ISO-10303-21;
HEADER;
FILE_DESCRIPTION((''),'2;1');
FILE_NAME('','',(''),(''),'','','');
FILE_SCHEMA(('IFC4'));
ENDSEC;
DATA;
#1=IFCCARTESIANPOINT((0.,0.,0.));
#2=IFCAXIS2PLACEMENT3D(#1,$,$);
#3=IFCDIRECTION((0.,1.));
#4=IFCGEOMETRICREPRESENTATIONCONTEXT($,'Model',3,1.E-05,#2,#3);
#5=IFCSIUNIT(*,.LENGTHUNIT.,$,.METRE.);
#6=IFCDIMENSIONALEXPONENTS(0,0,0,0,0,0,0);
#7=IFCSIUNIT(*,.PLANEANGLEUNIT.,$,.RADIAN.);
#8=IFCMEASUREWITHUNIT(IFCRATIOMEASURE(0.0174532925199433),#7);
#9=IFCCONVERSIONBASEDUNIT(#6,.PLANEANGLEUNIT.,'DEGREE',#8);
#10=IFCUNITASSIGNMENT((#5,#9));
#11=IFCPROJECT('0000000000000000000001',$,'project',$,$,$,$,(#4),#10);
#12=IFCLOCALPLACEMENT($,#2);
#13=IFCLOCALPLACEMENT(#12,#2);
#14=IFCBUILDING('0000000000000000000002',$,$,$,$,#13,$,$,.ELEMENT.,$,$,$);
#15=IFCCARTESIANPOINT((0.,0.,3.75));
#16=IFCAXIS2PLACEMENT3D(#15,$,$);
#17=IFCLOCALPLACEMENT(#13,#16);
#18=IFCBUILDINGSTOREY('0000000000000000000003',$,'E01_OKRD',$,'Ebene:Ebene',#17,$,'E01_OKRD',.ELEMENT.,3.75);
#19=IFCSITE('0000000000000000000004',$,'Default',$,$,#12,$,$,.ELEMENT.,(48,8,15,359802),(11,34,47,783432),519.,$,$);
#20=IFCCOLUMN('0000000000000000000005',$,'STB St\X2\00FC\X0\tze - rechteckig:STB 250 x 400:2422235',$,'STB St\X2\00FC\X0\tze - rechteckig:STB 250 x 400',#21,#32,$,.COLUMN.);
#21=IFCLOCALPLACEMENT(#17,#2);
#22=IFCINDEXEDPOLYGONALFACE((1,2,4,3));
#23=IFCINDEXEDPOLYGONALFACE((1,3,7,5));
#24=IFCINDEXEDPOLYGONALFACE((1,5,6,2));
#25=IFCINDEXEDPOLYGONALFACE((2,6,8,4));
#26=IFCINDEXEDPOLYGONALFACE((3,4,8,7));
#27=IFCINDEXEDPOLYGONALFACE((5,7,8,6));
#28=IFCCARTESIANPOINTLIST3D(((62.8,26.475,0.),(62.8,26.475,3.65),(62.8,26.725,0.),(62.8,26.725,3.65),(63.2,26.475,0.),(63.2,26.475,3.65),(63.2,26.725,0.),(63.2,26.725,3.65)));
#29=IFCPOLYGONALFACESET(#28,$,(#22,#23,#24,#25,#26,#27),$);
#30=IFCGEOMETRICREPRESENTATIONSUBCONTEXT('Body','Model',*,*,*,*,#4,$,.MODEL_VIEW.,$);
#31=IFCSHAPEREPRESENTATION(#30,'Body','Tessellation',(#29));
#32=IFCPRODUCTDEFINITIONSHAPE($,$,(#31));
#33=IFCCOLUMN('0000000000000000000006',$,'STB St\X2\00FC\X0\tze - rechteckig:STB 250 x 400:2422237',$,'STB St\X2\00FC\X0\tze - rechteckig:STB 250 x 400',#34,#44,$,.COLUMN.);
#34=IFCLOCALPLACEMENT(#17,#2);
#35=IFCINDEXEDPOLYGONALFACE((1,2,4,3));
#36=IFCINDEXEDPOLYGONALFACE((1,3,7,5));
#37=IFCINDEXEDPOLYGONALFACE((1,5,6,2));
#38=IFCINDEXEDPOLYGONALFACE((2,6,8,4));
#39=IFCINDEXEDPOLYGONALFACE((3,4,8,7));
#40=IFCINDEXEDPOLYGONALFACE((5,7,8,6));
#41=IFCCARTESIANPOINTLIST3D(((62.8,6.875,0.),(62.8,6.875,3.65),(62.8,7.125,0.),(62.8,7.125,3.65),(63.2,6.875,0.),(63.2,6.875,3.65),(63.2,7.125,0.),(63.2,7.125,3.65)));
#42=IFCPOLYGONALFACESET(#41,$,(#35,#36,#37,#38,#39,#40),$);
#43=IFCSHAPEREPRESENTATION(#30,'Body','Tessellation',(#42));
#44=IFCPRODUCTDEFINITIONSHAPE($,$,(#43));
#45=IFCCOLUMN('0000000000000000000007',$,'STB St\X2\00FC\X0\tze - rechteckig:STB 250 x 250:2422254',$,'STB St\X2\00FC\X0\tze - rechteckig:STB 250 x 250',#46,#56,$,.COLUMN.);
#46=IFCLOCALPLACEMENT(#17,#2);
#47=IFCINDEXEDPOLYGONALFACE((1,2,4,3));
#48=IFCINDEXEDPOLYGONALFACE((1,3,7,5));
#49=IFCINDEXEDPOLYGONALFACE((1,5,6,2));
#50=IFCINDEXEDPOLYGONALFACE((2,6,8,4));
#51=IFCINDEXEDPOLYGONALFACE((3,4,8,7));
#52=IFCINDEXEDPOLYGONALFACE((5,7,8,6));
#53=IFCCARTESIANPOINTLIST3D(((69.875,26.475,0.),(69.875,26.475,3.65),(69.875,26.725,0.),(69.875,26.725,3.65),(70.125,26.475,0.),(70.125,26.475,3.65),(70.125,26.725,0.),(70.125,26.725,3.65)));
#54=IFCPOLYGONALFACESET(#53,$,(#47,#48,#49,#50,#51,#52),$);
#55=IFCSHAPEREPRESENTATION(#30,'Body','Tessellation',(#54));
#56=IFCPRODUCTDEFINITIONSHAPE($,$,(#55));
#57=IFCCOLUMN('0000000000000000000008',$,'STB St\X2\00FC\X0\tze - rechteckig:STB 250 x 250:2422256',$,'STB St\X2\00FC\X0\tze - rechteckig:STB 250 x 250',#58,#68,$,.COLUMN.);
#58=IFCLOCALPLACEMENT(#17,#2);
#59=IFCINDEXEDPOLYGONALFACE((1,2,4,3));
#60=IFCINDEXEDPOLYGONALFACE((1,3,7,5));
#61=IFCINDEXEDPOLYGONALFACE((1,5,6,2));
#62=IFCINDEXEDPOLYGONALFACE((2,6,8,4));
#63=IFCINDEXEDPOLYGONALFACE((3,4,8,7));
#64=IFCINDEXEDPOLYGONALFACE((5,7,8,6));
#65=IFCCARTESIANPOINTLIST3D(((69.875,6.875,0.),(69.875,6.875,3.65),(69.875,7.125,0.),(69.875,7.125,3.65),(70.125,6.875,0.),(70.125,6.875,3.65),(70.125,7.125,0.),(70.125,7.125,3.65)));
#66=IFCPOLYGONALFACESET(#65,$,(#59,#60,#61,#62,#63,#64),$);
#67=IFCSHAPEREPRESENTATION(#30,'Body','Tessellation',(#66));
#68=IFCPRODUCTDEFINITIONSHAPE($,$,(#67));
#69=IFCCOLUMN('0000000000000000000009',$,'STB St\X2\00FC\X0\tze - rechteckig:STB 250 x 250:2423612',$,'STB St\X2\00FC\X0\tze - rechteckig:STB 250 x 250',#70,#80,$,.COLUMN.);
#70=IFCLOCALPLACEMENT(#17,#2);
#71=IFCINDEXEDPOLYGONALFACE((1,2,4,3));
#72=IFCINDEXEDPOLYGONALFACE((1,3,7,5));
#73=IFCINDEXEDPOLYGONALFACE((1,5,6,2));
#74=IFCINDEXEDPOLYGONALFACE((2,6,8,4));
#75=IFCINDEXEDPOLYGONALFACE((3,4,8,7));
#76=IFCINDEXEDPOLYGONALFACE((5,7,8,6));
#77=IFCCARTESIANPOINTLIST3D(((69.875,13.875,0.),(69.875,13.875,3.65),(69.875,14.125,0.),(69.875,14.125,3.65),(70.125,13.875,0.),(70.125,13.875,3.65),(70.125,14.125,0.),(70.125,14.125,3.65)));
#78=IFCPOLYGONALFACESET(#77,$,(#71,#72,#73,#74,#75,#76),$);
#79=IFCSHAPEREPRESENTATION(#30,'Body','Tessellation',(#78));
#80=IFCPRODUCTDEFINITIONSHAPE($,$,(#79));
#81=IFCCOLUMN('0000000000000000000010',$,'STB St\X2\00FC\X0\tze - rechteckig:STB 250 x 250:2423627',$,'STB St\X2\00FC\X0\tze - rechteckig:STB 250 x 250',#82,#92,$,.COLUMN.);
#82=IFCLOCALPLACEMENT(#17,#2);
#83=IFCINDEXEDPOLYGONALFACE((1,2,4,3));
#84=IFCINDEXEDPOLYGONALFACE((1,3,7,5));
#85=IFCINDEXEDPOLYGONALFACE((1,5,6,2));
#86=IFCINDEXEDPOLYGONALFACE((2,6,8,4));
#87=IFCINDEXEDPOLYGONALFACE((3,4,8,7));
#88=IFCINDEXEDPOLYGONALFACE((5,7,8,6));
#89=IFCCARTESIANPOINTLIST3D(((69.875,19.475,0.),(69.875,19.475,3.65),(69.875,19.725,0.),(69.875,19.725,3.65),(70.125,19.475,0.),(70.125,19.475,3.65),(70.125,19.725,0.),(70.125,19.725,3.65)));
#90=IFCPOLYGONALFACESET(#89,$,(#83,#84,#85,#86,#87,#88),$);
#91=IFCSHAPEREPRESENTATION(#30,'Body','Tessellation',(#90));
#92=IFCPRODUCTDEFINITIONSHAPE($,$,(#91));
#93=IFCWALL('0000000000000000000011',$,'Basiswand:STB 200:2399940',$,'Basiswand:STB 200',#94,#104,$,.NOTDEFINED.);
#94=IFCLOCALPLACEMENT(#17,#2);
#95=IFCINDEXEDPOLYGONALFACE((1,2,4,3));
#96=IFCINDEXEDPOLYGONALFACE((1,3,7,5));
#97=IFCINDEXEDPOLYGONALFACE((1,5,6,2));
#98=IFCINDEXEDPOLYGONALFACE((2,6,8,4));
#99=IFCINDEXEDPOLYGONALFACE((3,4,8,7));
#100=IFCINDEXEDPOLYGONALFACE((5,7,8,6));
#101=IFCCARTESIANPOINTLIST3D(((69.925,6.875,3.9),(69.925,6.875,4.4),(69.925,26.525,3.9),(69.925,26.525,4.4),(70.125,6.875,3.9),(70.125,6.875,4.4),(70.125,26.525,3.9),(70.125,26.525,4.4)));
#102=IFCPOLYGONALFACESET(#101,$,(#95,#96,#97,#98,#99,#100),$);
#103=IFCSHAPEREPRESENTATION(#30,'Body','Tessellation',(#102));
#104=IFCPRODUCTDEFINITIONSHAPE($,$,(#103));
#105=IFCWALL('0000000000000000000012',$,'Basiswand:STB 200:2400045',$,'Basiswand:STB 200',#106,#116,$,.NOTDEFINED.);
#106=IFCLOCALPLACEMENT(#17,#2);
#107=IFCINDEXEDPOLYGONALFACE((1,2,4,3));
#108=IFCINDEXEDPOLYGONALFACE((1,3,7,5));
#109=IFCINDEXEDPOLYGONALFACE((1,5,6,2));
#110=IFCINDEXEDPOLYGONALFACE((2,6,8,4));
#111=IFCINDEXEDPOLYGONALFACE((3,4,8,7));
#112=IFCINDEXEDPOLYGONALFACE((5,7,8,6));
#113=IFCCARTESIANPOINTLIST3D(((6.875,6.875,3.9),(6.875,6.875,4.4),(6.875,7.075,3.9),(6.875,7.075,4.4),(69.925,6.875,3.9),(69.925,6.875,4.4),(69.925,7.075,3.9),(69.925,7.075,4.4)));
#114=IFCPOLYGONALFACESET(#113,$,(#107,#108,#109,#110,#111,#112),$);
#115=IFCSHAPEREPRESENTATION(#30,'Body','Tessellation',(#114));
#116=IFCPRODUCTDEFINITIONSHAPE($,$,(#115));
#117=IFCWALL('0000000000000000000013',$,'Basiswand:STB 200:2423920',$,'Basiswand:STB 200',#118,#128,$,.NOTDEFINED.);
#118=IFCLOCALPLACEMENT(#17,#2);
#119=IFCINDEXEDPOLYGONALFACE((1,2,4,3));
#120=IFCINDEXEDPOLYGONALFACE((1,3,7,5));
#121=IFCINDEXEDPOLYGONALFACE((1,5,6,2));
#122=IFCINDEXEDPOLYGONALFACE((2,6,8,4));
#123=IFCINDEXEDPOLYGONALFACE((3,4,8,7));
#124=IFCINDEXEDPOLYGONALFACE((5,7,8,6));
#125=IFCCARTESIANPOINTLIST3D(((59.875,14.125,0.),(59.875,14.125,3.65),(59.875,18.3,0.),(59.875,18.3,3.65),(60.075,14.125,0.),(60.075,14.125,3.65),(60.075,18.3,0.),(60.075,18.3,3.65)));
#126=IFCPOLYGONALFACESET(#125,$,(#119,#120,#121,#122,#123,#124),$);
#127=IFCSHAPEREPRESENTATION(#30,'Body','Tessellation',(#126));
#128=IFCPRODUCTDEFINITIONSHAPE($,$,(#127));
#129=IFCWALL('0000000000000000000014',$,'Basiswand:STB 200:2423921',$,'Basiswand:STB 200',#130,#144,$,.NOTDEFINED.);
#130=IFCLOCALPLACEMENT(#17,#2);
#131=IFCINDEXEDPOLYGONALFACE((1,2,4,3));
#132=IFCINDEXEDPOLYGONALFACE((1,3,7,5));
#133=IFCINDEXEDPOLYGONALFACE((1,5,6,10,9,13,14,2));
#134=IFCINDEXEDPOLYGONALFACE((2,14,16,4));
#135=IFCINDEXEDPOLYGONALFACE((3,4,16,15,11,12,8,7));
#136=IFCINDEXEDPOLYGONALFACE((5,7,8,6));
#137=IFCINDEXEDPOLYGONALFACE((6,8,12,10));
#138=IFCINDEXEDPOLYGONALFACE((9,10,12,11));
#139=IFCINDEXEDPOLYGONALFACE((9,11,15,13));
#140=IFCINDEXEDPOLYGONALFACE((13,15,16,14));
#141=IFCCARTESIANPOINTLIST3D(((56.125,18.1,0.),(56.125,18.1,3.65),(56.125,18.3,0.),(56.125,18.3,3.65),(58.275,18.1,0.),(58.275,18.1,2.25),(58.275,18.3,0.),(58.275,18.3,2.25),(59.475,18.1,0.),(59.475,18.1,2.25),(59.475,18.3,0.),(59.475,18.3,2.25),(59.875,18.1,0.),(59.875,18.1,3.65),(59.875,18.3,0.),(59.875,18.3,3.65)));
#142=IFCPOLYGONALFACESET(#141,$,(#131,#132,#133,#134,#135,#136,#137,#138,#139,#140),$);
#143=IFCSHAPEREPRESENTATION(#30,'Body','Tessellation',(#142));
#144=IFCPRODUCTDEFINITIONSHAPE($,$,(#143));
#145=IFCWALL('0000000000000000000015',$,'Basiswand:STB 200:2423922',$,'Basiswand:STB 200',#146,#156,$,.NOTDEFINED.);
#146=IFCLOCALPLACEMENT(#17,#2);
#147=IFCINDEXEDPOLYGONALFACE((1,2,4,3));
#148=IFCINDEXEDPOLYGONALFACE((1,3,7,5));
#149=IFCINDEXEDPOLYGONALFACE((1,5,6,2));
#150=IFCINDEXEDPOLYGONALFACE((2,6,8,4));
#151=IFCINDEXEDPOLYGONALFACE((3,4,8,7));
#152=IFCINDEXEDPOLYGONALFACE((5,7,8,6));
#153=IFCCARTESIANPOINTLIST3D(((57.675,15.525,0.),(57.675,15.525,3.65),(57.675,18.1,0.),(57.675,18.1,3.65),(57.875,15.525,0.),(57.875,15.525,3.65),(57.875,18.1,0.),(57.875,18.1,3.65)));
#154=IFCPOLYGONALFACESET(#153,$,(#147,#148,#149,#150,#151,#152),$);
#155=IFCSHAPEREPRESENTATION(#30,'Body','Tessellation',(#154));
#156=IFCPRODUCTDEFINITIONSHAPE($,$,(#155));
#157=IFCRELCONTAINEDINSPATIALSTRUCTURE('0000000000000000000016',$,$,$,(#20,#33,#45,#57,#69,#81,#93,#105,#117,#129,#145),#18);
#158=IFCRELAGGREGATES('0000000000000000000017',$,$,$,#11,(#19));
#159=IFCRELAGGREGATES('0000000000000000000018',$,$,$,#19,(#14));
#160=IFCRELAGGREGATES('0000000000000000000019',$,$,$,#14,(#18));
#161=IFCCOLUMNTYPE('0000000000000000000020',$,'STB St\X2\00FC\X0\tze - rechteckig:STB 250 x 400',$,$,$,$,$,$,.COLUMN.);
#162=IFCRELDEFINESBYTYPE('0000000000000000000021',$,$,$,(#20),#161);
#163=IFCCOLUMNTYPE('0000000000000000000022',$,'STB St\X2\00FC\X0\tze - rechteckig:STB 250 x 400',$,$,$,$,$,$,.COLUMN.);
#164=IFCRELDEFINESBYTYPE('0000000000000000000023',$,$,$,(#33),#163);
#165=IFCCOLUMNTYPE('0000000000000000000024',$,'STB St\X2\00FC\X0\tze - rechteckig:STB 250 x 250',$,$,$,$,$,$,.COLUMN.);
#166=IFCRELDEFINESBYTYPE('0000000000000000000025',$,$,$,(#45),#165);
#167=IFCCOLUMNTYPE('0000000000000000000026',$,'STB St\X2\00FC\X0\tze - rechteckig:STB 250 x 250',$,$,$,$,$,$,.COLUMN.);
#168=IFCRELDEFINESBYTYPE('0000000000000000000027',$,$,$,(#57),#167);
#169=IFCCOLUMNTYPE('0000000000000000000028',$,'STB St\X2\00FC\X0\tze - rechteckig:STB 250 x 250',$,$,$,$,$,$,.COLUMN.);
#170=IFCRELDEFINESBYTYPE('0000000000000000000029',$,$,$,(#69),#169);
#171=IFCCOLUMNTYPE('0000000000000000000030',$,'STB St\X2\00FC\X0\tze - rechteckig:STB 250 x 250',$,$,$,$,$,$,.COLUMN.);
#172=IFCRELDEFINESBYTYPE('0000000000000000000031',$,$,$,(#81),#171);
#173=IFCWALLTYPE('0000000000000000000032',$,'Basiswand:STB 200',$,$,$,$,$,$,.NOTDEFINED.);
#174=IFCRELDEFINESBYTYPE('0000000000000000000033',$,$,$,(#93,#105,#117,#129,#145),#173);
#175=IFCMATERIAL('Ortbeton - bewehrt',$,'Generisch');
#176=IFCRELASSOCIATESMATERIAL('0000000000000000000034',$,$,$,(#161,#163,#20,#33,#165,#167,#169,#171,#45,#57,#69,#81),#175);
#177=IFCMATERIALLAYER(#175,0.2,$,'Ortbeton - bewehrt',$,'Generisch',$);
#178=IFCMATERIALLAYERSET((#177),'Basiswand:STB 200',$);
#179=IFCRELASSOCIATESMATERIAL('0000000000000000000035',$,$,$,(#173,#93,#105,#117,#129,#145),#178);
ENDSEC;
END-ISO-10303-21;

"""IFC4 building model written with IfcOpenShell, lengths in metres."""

from ifc_helpers import new_model, entity, si_unit, converted_unit, direction, frame, frame_2d, origin, origin_2d_with_axis, place, context, subcontext, project, spatial, rectangle, extrude, source, transform, mapped, material, layer, layer_set, layer_usage, material_profile, profile_set, profile_usage, type_object, type_shapes, element, save


model = new_model("IFC4")

# Units and contexts
model_context = context("Model", 3, precision=1e-05, world=origin(), true_north=direction((0.0, 1.0)))
body_context = subcontext(model_context, "Body", "Model", "MODEL_VIEW")
ifc_project = project(units=[si_unit("LENGTHUNIT", "METRE"), converted_unit("PLANEANGLEUNIT", "DEGREE", entity("IfcRatioMeasure", 0.0174532925199433), si_unit("PLANEANGLEUNIT", "RADIAN"), dimensions=[0, 0, 0, 0, 0, 0, 0])], contexts=[model_context])

# Site, building, storey
site_placement = place(None, frame((0.0, 0.0, 0.0)))
site = spatial("IfcSite", under=ifc_project, at=site_placement, Name="Default", CompositionType="ELEMENT", RefLatitude=(48, 8, 15, 359802), RefLongitude=(11, 34, 47, 783432), RefElevation=519.0)
building_placement = place(site_placement, origin())
building = spatial("IfcBuilding", under=site, at=building_placement, CompositionType="ELEMENT")
storey_placement = place(building_placement, frame((0.0, 0.0, 3.75)))
storey = spatial("IfcBuildingStorey", under=building, at=storey_placement, Name="E01_OKRD", ObjectType="Ebene:Ebene", LongName="E01_OKRD", CompositionType="ELEMENT", Elevation=3.75)

# Columns
ifc_material_1 = material(Name="Ortbeton - bewehrt", Category="Generisch")
ifc_material_profile_1 = material_profile(ifc_material_1, rectangle(XDim=0.4, YDim=0.25, at=frame_2d((0.0, 0.0), x_axis=(1.0, 0.0))), Name="STB 250 x 400")
ifc_profile_set_1 = profile_set([ifc_material_profile_1], Name="STB 250 x 400")
ifc_profile_usage_1 = profile_usage(ifc_profile_set_1)
column_type_1 = type_object("IfcColumnType", Name="STB Stütze - rechteckig:STB 250 x 400", PredefinedType="COLUMN", material=ifc_profile_set_1)
shared_shape_1 = source(origin(), body_context, "Body", "SweptSolid", [
    extrude(rectangle(XDim=0.4, YDim=0.25, at=origin_2d_with_axis()), frame((0.2, 0.125, 0.0), z_axis=(0.0, 0.0, 1.0), x_axis=(-1.0, 0.0, 0.0)), (0.0, 0.0, 1.0), 3.65),
])
type_shapes(column_type_1, [shared_shape_1])
column_1_placement = place(storey_placement, frame((62.8, 26.475, 0.0)))
element("IfcColumn", 1, at=column_1_placement, inside=storey, type_object=column_type_1, material=ifc_profile_usage_1, Name="STB Stütze - rechteckig:STB 250 x 400:2422235", ObjectType="STB Stütze - rechteckig:STB 250 x 400", PredefinedType="COLUMN", context=body_context, shape_type="MappedRepresentation", body=[
    mapped(shared_shape_1, transform((0.0, 0.0, 0.0), scale=1.0)),
])
ifc_profile_usage_2 = profile_usage(ifc_profile_set_1)
column_type_2 = type_object("IfcColumnType", Name="STB Stütze - rechteckig:STB 250 x 400", PredefinedType="COLUMN", material=ifc_profile_set_1)
shared_shape_2 = source(origin(), body_context, "Body", "SweptSolid", [
    extrude(rectangle(XDim=0.4, YDim=0.25, at=frame_2d((0.0, 0.0), x_axis=(1.0, 0.0))), frame((0.2, 0.125, 0.0), z_axis=(0.0, 0.0, 1.0), x_axis=(-1.0, 0.0, 0.0)), (0.0, 0.0, 1.0), 3.65),
])
type_shapes(column_type_2, [shared_shape_2])
column_2_placement = place(storey_placement, frame((62.8, 6.875, 0.0)))
element("IfcColumn", 2, at=column_2_placement, inside=storey, type_object=column_type_2, material=ifc_profile_usage_2, Name="STB Stütze - rechteckig:STB 250 x 400:2422237", ObjectType="STB Stütze - rechteckig:STB 250 x 400", PredefinedType="COLUMN", context=body_context, shape_type="MappedRepresentation", body=[
    mapped(shared_shape_2, transform((0.0, 0.0, 0.0), scale=1.0)),
])
ifc_material_profile_2 = material_profile(ifc_material_1, rectangle(XDim=0.25, YDim=0.25, at=origin_2d_with_axis()), Name="STB 250 x 250")
ifc_profile_set_2 = profile_set([ifc_material_profile_2], Name="STB 250 x 250")
ifc_profile_usage_3 = profile_usage(ifc_profile_set_2)
column_type_3 = type_object("IfcColumnType", Name="STB Stütze - rechteckig:STB 250 x 250", PredefinedType="COLUMN", material=ifc_profile_set_2)
shared_shape_3 = source(origin(), body_context, "Body", "SweptSolid", [
    extrude(rectangle(XDim=0.25, YDim=0.25, at=frame_2d((0.0, 0.0), x_axis=(1.0, 0.0))), frame((0.125, 0.125, 0.0), z_axis=(0.0, 0.0, 1.0), x_axis=(-1.0, 0.0, 0.0)), (0.0, 0.0, 1.0), 3.65),
])
type_shapes(column_type_3, [shared_shape_3])
column_3_placement = place(storey_placement, frame((69.875, 26.475, 0.0)))
element("IfcColumn", 3, at=column_3_placement, inside=storey, type_object=column_type_3, material=ifc_profile_usage_3, Name="STB Stütze - rechteckig:STB 250 x 250:2422254", ObjectType="STB Stütze - rechteckig:STB 250 x 250", PredefinedType="COLUMN", context=body_context, shape_type="MappedRepresentation", body=[
    mapped(shared_shape_3, transform((0.0, 0.0, 0.0), scale=1.0)),
])
ifc_profile_usage_4 = profile_usage(ifc_profile_set_2)
column_type_4 = type_object("IfcColumnType", Name="STB Stütze - rechteckig:STB 250 x 250", PredefinedType="COLUMN", material=ifc_profile_set_2)
shared_shape_4 = source(origin(), body_context, "Body", "SweptSolid", [
    extrude(rectangle(XDim=0.25, YDim=0.25, at=frame_2d((0.0, 0.0), x_axis=(1.0, 0.0))), frame((0.125, 0.125, 0.0), z_axis=(0.0, 0.0, 1.0), x_axis=(-1.0, 0.0, 0.0)), (0.0, 0.0, 1.0), 3.65),
])
type_shapes(column_type_4, [shared_shape_4])
column_4_placement = place(storey_placement, frame((69.875, 6.875, 0.0)))
element("IfcColumn", 4, at=column_4_placement, inside=storey, type_object=column_type_4, material=ifc_profile_usage_4, Name="STB Stütze - rechteckig:STB 250 x 250:2422256", ObjectType="STB Stütze - rechteckig:STB 250 x 250", PredefinedType="COLUMN", context=body_context, shape_type="MappedRepresentation", body=[
    mapped(shared_shape_4, transform((0.0, 0.0, 0.0), scale=1.0)),
])
ifc_profile_usage_5 = profile_usage(ifc_profile_set_2)
column_type_5 = type_object("IfcColumnType", Name="STB Stütze - rechteckig:STB 250 x 250", PredefinedType="COLUMN", material=ifc_profile_set_2)
shared_shape_5 = source(origin(), body_context, "Body", "SweptSolid", [
    extrude(rectangle(XDim=0.25, YDim=0.25, at=frame_2d((0.0, 0.0), x_axis=(1.0, 0.0))), frame((0.125, 0.125, 0.0), z_axis=(0.0, 0.0, 1.0), x_axis=(0.0, 1.0, 0.0)), (0.0, 0.0, 1.0), 3.65),
])
type_shapes(column_type_5, [shared_shape_5])
column_5_placement = place(storey_placement, frame((69.875, 13.875, 0.0)))
element("IfcColumn", 5, at=column_5_placement, inside=storey, type_object=column_type_5, material=ifc_profile_usage_5, Name="STB Stütze - rechteckig:STB 250 x 250:2423612", ObjectType="STB Stütze - rechteckig:STB 250 x 250", PredefinedType="COLUMN", context=body_context, shape_type="MappedRepresentation", body=[
    mapped(shared_shape_5, transform((0.0, 0.0, 0.0), scale=1.0)),
])
ifc_profile_usage_6 = profile_usage(ifc_profile_set_2)
column_type_6 = type_object("IfcColumnType", Name="STB Stütze - rechteckig:STB 250 x 250", PredefinedType="COLUMN", material=ifc_profile_set_2)
shared_shape_6 = source(origin(), body_context, "Body", "SweptSolid", [
    extrude(rectangle(XDim=0.25, YDim=0.25, at=frame_2d((0.0, 0.0), x_axis=(1.0, 0.0))), frame((0.125, 0.125, 0.0), z_axis=(0.0, 0.0, 1.0), x_axis=(0.0, 1.0, 0.0)), (0.0, 0.0, 1.0), 3.65),
])
type_shapes(column_type_6, [shared_shape_6])
column_6_placement = place(storey_placement, frame((69.875, 19.475, 0.0)))
element("IfcColumn", 6, at=column_6_placement, inside=storey, type_object=column_type_6, material=ifc_profile_usage_6, Name="STB Stütze - rechteckig:STB 250 x 250:2423627", ObjectType="STB Stütze - rechteckig:STB 250 x 250", PredefinedType="COLUMN", context=body_context, shape_type="MappedRepresentation", body=[
    mapped(shared_shape_6, transform((0.0, 0.0, 0.0), scale=1.0)),
])

# Walls
ifc_layer_1 = layer(ifc_material_1, 0.2, Name="Ortbeton - bewehrt", Category="Generisch")
ifc_layer_set_1 = layer_set([ifc_layer_1], Name="Basiswand:STB 200")
ifc_layer_usage_1 = layer_usage(ifc_layer_set_1, "AXIS2", "NEGATIVE", 0.1)
wall_type_1 = type_object("IfcWallType", Name="Basiswand:STB 200", PredefinedType="NOTDEFINED", material=ifc_layer_set_1)
wall_1_placement = place(storey_placement, frame((70.025, 26.525, 3.9), z_axis=(0.0, 0.0, 1.0), x_axis=(0.0, -1.0, 0.0)))
element("IfcWall", 7, at=wall_1_placement, inside=storey, type_object=wall_type_1, material=ifc_layer_usage_1, Name="Basiswand:STB 200:2399940", ObjectType="Basiswand:STB 200", PredefinedType="NOTDEFINED", context=body_context, shape_type="SweptSolid", body=[
    extrude(rectangle(XDim=19.65, YDim=0.2, at=frame_2d((9.825, 0.0), x_axis=(-1.0, 0.0))), origin(), (0.0, 0.0, 1.0), 0.5),
])
ifc_layer_usage_2 = layer_usage(ifc_layer_set_1, "AXIS2", "NEGATIVE", 0.1)
wall_2_placement = place(storey_placement, frame((69.925, 6.975, 3.9), z_axis=(0.0, 0.0, 1.0), x_axis=(-1.0, 0.0, 0.0)))
element("IfcWall", 8, at=wall_2_placement, inside=storey, type_object=wall_type_1, material=ifc_layer_usage_2, Name="Basiswand:STB 200:2400045", ObjectType="Basiswand:STB 200", PredefinedType="NOTDEFINED", context=body_context, shape_type="SweptSolid", body=[
    extrude(rectangle(XDim=63.05, YDim=0.2, at=frame_2d((31.525, 0.0), x_axis=(-1.0, 0.0))), origin(), (0.0, 0.0, 1.0), 0.5),
])
ifc_layer_usage_3 = layer_usage(ifc_layer_set_1, "AXIS2", "POSITIVE", -0.1)
wall_3_placement = place(storey_placement, frame((59.975, 14.125, 0.0), z_axis=(0.0, 0.0, 1.0), x_axis=(0.0, 1.0, 0.0)))
element("IfcWall", 9, at=wall_3_placement, inside=storey, type_object=wall_type_1, material=ifc_layer_usage_3, Name="Basiswand:STB 200:2423920", ObjectType="Basiswand:STB 200", PredefinedType="NOTDEFINED", context=body_context, shape_type="SweptSolid", body=[
    extrude(rectangle(XDim=4.175, YDim=0.2, at=frame_2d((2.0875, 0.0), x_axis=(-1.0, 0.0))), origin(), (0.0, 0.0, 1.0), 3.65),
])

# Wall, opening
ifc_layer_usage_4 = layer_usage(ifc_layer_set_1, "AXIS2", "POSITIVE", -0.1)
wall_4_placement = place(storey_placement, frame((59.875, 18.2, 0.0), z_axis=(0.0, 0.0, 1.0), x_axis=(-1.0, 0.0, 0.0)))
wall_4 = element("IfcWall", 10, at=wall_4_placement, inside=storey, type_object=wall_type_1, material=ifc_layer_usage_4, Name="Basiswand:STB 200:2423921", ObjectType="Basiswand:STB 200", PredefinedType="NOTDEFINED", context=body_context, shape_type="SweptSolid", body=[
    extrude(rectangle(XDim=3.75, YDim=0.2, at=frame_2d((1.875, 0.0), x_axis=(-1.0, 0.0))), origin(), (0.0, 0.0, 1.0), 3.65),
])
opening_1_placement = place(wall_4_placement, frame((1.6, 0.1, -0.03)))
element("IfcOpeningElement", 11, at=opening_1_placement, cuts=wall_4, ObjectType="Opening", PredefinedType="OPENING", context=body_context, shape_type="SweptSolid", body=[
    extrude(rectangle(XDim=2.28, YDim=1.2, at=frame_2d((1.14, 0.6), x_axis=(1.0, 0.0))), frame((0.0, 0.0, 0.0), z_axis=(0.0, -1.0, 0.0), x_axis=(0.0, 0.0, 1.0)), (0.0, 0.0, 1.0), 0.2),
])

# Wall
ifc_layer_usage_5 = layer_usage(ifc_layer_set_1, "AXIS2", "POSITIVE", -0.1)
wall_5_placement = place(storey_placement, frame((57.775, 18.1, 0.0), z_axis=(0.0, 0.0, 1.0), x_axis=(0.0, -1.0, 0.0)))
element("IfcWall", 12, at=wall_5_placement, inside=storey, type_object=wall_type_1, material=ifc_layer_usage_5, Name="Basiswand:STB 200:2423922", ObjectType="Basiswand:STB 200", PredefinedType="NOTDEFINED", context=body_context, shape_type="SweptSolid", body=[
    extrude(rectangle(XDim=2.575, YDim=0.2, at=frame_2d((1.2875, 0.0), x_axis=(-1.0, 0.0))), origin(), (0.0, 0.0, 1.0), 3.65),
])

save(model, "model.ifc")
